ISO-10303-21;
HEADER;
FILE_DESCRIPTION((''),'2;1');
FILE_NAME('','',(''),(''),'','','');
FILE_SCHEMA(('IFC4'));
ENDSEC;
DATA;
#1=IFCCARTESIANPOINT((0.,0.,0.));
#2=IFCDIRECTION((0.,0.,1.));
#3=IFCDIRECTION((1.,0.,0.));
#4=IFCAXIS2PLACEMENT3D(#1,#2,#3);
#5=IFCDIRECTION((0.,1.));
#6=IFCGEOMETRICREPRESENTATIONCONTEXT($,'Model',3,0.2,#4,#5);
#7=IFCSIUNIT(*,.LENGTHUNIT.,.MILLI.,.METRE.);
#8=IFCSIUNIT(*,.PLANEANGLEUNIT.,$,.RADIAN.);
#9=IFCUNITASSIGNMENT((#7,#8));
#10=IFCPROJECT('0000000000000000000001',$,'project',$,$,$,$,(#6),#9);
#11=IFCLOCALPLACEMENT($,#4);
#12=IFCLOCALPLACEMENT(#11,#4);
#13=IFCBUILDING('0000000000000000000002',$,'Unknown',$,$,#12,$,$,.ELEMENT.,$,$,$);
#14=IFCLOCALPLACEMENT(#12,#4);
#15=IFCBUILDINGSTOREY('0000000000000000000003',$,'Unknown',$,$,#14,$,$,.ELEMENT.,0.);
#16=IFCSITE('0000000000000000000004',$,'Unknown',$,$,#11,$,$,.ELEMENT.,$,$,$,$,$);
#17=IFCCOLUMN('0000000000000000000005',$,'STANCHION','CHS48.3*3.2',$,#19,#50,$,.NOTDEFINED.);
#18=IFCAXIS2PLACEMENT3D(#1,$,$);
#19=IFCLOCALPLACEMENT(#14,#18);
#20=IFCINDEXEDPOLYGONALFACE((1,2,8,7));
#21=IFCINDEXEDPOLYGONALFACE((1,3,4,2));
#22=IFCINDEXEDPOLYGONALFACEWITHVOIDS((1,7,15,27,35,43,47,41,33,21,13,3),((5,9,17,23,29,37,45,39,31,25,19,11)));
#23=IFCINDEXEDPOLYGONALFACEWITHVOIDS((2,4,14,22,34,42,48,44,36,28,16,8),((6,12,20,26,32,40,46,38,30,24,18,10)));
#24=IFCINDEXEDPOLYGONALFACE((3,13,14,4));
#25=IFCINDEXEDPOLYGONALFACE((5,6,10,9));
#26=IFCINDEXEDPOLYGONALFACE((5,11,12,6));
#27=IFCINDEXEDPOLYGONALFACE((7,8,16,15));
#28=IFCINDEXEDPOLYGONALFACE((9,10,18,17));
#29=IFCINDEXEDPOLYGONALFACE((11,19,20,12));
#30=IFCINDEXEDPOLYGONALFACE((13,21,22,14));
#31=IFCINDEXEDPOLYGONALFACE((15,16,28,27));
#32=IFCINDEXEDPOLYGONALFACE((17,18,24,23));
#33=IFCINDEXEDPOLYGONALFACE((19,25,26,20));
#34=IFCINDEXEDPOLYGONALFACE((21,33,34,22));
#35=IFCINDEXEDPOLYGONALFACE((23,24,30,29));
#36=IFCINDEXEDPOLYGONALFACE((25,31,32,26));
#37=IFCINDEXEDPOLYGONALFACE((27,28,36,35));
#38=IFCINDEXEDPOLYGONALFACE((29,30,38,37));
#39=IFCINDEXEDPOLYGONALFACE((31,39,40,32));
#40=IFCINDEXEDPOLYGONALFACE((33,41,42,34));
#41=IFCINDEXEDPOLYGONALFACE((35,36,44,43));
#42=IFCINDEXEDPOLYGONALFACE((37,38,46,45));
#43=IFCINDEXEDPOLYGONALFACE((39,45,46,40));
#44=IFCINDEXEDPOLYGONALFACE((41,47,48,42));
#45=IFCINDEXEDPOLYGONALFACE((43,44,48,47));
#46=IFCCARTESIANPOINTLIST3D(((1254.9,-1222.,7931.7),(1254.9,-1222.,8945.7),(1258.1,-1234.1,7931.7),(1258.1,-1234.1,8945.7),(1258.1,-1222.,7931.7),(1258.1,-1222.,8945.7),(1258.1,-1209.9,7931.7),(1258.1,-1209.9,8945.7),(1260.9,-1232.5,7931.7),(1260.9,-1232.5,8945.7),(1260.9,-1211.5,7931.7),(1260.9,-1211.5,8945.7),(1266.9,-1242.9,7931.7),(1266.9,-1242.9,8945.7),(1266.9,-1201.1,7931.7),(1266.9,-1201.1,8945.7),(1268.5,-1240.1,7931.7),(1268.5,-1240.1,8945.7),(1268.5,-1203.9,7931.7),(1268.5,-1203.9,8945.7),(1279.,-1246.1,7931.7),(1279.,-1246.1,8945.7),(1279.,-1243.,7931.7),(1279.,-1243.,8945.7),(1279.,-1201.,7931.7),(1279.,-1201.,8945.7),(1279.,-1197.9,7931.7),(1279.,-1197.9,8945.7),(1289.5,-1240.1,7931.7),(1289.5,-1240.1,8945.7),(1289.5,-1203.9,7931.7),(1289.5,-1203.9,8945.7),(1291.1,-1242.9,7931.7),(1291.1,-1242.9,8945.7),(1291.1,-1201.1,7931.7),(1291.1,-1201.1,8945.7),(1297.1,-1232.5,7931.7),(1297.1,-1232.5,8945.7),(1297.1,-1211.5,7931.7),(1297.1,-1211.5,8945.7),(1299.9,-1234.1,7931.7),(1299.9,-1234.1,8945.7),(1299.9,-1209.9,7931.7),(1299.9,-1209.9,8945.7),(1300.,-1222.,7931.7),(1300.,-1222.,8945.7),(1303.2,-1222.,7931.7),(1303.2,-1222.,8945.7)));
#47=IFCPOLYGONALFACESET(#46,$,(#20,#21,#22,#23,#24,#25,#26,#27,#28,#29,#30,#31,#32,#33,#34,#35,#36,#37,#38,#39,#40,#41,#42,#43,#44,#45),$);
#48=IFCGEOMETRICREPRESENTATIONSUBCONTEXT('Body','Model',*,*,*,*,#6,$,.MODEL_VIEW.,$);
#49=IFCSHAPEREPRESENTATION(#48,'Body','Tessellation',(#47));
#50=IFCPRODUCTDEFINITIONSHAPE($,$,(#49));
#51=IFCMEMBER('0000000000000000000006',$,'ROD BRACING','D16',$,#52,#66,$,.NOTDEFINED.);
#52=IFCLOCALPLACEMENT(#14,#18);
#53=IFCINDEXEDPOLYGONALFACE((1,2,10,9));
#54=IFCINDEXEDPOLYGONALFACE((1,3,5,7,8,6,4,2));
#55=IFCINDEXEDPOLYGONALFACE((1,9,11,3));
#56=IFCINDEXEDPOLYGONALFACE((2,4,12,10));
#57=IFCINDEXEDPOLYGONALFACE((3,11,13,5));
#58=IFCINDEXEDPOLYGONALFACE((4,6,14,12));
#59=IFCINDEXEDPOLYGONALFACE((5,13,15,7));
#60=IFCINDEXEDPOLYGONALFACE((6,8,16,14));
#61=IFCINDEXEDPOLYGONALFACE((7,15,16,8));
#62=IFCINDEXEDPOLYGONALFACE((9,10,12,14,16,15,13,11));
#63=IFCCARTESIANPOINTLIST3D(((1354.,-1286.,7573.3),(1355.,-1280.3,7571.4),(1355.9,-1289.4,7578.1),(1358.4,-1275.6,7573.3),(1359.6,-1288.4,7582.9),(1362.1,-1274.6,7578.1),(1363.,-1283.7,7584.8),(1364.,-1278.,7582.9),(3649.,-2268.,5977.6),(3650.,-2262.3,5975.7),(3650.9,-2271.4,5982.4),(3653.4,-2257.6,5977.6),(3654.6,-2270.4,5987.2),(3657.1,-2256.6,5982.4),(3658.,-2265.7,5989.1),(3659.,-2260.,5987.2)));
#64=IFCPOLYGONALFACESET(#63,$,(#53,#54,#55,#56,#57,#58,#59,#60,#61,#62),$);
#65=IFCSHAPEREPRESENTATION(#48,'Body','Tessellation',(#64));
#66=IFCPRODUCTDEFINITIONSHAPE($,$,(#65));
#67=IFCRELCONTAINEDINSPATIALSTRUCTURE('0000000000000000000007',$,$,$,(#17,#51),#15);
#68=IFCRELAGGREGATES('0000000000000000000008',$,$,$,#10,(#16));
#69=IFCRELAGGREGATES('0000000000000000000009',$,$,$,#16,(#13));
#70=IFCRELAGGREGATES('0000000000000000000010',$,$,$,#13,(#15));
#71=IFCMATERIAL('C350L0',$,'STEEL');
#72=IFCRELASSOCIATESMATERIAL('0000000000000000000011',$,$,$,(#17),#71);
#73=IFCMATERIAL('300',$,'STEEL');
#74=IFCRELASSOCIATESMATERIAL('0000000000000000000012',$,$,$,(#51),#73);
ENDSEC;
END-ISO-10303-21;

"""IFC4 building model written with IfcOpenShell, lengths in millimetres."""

from ifc_helpers import new_model, si_unit, direction, frame, origin_with_axes, place, context, subcontext, project, spatial, line, indexed_curve, outline, extrude, material, element, save


model = new_model("IFC4")

# Units and contexts
model_context = context("Model", 3, precision=0.2, world=origin_with_axes(), true_north=direction((0.0, 1.0)))
body_context = subcontext(model_context, "Body", "Model", "MODEL_VIEW")
ifc_project = project(units=[si_unit("LENGTHUNIT", "METRE", prefix="MILLI"), si_unit("PLANEANGLEUNIT", "RADIAN")], contexts=[model_context])

# Site, building, storey
site_placement = place(None, origin_with_axes())
site = spatial("IfcSite", under=ifc_project, at=site_placement, Name="Unknown", CompositionType="ELEMENT")
building_placement = place(site_placement, origin_with_axes())
building = spatial("IfcBuilding", under=site, at=building_placement, Name="Unknown", CompositionType="ELEMENT")
storey_placement = place(building_placement, origin_with_axes())
storey = spatial("IfcBuildingStorey", under=building, at=storey_placement, Name="Unknown", CompositionType="ELEMENT", Elevation=0.0)

# Column
ifc_material_1 = material(Name="C350L0", Category="STEEL")
column_placement = place(storey_placement, frame((1279.0, -1222.0, 7931.7), z_axis=(-1.0, 0.0, 0.0), x_axis=(0.0, 0.0, 1.0)))
element("IfcColumn", 1, at=column_placement, inside=storey, material=ifc_material_1, Name="STANCHION", Description="CHS48.3*3.2", PredefinedType="NOTDEFINED", context=body_context, shape_type="SolidModel", body=[
    extrude(outline(indexed_curve([(24.1, 0.0), (20.9, 12.1), (12.1, 20.9), (0.0, 24.1), (-12.1, 20.9), (-20.9, 12.1), (-24.1, 0.0), (-20.9, -12.1), (-12.1, -20.9), (0.0, -24.1), (12.1, -20.9), (20.9, -12.1)], segments=[line(1, 2, 3, 4, 5, 6, 7, 8, 9, 10, 11, 12, 1)]), holes=[indexed_curve([(20.9, 0.0), (18.1, -10.5), (10.5, -18.1), (0.0, -20.9), (-10.5, -18.1), (-18.1, -10.5), (-20.9, 0.0), (-18.1, 10.5), (-10.5, 18.1), (0.0, 20.9), (10.5, 18.1), (18.1, 10.5)], segments=[line(1, 2, 3, 4, 5, 6, 7, 8, 9, 10, 11, 12, 1)])]), frame((0.0, 0.0, 0.0), z_axis=(-1.0, 0.0, 0.0), x_axis=(0.0, 0.0, 1.0)), (0.0, 0.0, -1.0), 1014.0),
])

# Member
ifc_material_2 = material(Name="300", Category="STEEL")
member_1_placement = place(storey_placement, frame((1359.0, -1282.0, 7578.1), z_axis=(0.495171, -0.211877, 0.842564), x_axis=(0.774631, -0.331454, -0.538596)))
element("IfcMember", 2, at=member_1_placement, inside=storey, material=ifc_material_2, Name="ROD BRACING", Description="D16", PredefinedType="NOTDEFINED", context=body_context, shape_type="SolidModel", body=[
    extrude(outline(indexed_curve([(8.0, 0.0), (5.7, 5.7), (0.0, 8.0), (-5.7, 5.7), (-8.0, 0.0), (-5.7, -5.7), (0.0, -8.0), (5.7, -5.7)], segments=[line(1, 2, 3, 4, 5, 6, 7, 8, 1)])), frame((0.0, 0.0, 0.0), z_axis=(-1.0, 0.0, 0.0), x_axis=(0.0, 0.0, 1.0)), (0.0, 0.0, -1.0), 2962.7),
])

save(model, "model.ifc")
